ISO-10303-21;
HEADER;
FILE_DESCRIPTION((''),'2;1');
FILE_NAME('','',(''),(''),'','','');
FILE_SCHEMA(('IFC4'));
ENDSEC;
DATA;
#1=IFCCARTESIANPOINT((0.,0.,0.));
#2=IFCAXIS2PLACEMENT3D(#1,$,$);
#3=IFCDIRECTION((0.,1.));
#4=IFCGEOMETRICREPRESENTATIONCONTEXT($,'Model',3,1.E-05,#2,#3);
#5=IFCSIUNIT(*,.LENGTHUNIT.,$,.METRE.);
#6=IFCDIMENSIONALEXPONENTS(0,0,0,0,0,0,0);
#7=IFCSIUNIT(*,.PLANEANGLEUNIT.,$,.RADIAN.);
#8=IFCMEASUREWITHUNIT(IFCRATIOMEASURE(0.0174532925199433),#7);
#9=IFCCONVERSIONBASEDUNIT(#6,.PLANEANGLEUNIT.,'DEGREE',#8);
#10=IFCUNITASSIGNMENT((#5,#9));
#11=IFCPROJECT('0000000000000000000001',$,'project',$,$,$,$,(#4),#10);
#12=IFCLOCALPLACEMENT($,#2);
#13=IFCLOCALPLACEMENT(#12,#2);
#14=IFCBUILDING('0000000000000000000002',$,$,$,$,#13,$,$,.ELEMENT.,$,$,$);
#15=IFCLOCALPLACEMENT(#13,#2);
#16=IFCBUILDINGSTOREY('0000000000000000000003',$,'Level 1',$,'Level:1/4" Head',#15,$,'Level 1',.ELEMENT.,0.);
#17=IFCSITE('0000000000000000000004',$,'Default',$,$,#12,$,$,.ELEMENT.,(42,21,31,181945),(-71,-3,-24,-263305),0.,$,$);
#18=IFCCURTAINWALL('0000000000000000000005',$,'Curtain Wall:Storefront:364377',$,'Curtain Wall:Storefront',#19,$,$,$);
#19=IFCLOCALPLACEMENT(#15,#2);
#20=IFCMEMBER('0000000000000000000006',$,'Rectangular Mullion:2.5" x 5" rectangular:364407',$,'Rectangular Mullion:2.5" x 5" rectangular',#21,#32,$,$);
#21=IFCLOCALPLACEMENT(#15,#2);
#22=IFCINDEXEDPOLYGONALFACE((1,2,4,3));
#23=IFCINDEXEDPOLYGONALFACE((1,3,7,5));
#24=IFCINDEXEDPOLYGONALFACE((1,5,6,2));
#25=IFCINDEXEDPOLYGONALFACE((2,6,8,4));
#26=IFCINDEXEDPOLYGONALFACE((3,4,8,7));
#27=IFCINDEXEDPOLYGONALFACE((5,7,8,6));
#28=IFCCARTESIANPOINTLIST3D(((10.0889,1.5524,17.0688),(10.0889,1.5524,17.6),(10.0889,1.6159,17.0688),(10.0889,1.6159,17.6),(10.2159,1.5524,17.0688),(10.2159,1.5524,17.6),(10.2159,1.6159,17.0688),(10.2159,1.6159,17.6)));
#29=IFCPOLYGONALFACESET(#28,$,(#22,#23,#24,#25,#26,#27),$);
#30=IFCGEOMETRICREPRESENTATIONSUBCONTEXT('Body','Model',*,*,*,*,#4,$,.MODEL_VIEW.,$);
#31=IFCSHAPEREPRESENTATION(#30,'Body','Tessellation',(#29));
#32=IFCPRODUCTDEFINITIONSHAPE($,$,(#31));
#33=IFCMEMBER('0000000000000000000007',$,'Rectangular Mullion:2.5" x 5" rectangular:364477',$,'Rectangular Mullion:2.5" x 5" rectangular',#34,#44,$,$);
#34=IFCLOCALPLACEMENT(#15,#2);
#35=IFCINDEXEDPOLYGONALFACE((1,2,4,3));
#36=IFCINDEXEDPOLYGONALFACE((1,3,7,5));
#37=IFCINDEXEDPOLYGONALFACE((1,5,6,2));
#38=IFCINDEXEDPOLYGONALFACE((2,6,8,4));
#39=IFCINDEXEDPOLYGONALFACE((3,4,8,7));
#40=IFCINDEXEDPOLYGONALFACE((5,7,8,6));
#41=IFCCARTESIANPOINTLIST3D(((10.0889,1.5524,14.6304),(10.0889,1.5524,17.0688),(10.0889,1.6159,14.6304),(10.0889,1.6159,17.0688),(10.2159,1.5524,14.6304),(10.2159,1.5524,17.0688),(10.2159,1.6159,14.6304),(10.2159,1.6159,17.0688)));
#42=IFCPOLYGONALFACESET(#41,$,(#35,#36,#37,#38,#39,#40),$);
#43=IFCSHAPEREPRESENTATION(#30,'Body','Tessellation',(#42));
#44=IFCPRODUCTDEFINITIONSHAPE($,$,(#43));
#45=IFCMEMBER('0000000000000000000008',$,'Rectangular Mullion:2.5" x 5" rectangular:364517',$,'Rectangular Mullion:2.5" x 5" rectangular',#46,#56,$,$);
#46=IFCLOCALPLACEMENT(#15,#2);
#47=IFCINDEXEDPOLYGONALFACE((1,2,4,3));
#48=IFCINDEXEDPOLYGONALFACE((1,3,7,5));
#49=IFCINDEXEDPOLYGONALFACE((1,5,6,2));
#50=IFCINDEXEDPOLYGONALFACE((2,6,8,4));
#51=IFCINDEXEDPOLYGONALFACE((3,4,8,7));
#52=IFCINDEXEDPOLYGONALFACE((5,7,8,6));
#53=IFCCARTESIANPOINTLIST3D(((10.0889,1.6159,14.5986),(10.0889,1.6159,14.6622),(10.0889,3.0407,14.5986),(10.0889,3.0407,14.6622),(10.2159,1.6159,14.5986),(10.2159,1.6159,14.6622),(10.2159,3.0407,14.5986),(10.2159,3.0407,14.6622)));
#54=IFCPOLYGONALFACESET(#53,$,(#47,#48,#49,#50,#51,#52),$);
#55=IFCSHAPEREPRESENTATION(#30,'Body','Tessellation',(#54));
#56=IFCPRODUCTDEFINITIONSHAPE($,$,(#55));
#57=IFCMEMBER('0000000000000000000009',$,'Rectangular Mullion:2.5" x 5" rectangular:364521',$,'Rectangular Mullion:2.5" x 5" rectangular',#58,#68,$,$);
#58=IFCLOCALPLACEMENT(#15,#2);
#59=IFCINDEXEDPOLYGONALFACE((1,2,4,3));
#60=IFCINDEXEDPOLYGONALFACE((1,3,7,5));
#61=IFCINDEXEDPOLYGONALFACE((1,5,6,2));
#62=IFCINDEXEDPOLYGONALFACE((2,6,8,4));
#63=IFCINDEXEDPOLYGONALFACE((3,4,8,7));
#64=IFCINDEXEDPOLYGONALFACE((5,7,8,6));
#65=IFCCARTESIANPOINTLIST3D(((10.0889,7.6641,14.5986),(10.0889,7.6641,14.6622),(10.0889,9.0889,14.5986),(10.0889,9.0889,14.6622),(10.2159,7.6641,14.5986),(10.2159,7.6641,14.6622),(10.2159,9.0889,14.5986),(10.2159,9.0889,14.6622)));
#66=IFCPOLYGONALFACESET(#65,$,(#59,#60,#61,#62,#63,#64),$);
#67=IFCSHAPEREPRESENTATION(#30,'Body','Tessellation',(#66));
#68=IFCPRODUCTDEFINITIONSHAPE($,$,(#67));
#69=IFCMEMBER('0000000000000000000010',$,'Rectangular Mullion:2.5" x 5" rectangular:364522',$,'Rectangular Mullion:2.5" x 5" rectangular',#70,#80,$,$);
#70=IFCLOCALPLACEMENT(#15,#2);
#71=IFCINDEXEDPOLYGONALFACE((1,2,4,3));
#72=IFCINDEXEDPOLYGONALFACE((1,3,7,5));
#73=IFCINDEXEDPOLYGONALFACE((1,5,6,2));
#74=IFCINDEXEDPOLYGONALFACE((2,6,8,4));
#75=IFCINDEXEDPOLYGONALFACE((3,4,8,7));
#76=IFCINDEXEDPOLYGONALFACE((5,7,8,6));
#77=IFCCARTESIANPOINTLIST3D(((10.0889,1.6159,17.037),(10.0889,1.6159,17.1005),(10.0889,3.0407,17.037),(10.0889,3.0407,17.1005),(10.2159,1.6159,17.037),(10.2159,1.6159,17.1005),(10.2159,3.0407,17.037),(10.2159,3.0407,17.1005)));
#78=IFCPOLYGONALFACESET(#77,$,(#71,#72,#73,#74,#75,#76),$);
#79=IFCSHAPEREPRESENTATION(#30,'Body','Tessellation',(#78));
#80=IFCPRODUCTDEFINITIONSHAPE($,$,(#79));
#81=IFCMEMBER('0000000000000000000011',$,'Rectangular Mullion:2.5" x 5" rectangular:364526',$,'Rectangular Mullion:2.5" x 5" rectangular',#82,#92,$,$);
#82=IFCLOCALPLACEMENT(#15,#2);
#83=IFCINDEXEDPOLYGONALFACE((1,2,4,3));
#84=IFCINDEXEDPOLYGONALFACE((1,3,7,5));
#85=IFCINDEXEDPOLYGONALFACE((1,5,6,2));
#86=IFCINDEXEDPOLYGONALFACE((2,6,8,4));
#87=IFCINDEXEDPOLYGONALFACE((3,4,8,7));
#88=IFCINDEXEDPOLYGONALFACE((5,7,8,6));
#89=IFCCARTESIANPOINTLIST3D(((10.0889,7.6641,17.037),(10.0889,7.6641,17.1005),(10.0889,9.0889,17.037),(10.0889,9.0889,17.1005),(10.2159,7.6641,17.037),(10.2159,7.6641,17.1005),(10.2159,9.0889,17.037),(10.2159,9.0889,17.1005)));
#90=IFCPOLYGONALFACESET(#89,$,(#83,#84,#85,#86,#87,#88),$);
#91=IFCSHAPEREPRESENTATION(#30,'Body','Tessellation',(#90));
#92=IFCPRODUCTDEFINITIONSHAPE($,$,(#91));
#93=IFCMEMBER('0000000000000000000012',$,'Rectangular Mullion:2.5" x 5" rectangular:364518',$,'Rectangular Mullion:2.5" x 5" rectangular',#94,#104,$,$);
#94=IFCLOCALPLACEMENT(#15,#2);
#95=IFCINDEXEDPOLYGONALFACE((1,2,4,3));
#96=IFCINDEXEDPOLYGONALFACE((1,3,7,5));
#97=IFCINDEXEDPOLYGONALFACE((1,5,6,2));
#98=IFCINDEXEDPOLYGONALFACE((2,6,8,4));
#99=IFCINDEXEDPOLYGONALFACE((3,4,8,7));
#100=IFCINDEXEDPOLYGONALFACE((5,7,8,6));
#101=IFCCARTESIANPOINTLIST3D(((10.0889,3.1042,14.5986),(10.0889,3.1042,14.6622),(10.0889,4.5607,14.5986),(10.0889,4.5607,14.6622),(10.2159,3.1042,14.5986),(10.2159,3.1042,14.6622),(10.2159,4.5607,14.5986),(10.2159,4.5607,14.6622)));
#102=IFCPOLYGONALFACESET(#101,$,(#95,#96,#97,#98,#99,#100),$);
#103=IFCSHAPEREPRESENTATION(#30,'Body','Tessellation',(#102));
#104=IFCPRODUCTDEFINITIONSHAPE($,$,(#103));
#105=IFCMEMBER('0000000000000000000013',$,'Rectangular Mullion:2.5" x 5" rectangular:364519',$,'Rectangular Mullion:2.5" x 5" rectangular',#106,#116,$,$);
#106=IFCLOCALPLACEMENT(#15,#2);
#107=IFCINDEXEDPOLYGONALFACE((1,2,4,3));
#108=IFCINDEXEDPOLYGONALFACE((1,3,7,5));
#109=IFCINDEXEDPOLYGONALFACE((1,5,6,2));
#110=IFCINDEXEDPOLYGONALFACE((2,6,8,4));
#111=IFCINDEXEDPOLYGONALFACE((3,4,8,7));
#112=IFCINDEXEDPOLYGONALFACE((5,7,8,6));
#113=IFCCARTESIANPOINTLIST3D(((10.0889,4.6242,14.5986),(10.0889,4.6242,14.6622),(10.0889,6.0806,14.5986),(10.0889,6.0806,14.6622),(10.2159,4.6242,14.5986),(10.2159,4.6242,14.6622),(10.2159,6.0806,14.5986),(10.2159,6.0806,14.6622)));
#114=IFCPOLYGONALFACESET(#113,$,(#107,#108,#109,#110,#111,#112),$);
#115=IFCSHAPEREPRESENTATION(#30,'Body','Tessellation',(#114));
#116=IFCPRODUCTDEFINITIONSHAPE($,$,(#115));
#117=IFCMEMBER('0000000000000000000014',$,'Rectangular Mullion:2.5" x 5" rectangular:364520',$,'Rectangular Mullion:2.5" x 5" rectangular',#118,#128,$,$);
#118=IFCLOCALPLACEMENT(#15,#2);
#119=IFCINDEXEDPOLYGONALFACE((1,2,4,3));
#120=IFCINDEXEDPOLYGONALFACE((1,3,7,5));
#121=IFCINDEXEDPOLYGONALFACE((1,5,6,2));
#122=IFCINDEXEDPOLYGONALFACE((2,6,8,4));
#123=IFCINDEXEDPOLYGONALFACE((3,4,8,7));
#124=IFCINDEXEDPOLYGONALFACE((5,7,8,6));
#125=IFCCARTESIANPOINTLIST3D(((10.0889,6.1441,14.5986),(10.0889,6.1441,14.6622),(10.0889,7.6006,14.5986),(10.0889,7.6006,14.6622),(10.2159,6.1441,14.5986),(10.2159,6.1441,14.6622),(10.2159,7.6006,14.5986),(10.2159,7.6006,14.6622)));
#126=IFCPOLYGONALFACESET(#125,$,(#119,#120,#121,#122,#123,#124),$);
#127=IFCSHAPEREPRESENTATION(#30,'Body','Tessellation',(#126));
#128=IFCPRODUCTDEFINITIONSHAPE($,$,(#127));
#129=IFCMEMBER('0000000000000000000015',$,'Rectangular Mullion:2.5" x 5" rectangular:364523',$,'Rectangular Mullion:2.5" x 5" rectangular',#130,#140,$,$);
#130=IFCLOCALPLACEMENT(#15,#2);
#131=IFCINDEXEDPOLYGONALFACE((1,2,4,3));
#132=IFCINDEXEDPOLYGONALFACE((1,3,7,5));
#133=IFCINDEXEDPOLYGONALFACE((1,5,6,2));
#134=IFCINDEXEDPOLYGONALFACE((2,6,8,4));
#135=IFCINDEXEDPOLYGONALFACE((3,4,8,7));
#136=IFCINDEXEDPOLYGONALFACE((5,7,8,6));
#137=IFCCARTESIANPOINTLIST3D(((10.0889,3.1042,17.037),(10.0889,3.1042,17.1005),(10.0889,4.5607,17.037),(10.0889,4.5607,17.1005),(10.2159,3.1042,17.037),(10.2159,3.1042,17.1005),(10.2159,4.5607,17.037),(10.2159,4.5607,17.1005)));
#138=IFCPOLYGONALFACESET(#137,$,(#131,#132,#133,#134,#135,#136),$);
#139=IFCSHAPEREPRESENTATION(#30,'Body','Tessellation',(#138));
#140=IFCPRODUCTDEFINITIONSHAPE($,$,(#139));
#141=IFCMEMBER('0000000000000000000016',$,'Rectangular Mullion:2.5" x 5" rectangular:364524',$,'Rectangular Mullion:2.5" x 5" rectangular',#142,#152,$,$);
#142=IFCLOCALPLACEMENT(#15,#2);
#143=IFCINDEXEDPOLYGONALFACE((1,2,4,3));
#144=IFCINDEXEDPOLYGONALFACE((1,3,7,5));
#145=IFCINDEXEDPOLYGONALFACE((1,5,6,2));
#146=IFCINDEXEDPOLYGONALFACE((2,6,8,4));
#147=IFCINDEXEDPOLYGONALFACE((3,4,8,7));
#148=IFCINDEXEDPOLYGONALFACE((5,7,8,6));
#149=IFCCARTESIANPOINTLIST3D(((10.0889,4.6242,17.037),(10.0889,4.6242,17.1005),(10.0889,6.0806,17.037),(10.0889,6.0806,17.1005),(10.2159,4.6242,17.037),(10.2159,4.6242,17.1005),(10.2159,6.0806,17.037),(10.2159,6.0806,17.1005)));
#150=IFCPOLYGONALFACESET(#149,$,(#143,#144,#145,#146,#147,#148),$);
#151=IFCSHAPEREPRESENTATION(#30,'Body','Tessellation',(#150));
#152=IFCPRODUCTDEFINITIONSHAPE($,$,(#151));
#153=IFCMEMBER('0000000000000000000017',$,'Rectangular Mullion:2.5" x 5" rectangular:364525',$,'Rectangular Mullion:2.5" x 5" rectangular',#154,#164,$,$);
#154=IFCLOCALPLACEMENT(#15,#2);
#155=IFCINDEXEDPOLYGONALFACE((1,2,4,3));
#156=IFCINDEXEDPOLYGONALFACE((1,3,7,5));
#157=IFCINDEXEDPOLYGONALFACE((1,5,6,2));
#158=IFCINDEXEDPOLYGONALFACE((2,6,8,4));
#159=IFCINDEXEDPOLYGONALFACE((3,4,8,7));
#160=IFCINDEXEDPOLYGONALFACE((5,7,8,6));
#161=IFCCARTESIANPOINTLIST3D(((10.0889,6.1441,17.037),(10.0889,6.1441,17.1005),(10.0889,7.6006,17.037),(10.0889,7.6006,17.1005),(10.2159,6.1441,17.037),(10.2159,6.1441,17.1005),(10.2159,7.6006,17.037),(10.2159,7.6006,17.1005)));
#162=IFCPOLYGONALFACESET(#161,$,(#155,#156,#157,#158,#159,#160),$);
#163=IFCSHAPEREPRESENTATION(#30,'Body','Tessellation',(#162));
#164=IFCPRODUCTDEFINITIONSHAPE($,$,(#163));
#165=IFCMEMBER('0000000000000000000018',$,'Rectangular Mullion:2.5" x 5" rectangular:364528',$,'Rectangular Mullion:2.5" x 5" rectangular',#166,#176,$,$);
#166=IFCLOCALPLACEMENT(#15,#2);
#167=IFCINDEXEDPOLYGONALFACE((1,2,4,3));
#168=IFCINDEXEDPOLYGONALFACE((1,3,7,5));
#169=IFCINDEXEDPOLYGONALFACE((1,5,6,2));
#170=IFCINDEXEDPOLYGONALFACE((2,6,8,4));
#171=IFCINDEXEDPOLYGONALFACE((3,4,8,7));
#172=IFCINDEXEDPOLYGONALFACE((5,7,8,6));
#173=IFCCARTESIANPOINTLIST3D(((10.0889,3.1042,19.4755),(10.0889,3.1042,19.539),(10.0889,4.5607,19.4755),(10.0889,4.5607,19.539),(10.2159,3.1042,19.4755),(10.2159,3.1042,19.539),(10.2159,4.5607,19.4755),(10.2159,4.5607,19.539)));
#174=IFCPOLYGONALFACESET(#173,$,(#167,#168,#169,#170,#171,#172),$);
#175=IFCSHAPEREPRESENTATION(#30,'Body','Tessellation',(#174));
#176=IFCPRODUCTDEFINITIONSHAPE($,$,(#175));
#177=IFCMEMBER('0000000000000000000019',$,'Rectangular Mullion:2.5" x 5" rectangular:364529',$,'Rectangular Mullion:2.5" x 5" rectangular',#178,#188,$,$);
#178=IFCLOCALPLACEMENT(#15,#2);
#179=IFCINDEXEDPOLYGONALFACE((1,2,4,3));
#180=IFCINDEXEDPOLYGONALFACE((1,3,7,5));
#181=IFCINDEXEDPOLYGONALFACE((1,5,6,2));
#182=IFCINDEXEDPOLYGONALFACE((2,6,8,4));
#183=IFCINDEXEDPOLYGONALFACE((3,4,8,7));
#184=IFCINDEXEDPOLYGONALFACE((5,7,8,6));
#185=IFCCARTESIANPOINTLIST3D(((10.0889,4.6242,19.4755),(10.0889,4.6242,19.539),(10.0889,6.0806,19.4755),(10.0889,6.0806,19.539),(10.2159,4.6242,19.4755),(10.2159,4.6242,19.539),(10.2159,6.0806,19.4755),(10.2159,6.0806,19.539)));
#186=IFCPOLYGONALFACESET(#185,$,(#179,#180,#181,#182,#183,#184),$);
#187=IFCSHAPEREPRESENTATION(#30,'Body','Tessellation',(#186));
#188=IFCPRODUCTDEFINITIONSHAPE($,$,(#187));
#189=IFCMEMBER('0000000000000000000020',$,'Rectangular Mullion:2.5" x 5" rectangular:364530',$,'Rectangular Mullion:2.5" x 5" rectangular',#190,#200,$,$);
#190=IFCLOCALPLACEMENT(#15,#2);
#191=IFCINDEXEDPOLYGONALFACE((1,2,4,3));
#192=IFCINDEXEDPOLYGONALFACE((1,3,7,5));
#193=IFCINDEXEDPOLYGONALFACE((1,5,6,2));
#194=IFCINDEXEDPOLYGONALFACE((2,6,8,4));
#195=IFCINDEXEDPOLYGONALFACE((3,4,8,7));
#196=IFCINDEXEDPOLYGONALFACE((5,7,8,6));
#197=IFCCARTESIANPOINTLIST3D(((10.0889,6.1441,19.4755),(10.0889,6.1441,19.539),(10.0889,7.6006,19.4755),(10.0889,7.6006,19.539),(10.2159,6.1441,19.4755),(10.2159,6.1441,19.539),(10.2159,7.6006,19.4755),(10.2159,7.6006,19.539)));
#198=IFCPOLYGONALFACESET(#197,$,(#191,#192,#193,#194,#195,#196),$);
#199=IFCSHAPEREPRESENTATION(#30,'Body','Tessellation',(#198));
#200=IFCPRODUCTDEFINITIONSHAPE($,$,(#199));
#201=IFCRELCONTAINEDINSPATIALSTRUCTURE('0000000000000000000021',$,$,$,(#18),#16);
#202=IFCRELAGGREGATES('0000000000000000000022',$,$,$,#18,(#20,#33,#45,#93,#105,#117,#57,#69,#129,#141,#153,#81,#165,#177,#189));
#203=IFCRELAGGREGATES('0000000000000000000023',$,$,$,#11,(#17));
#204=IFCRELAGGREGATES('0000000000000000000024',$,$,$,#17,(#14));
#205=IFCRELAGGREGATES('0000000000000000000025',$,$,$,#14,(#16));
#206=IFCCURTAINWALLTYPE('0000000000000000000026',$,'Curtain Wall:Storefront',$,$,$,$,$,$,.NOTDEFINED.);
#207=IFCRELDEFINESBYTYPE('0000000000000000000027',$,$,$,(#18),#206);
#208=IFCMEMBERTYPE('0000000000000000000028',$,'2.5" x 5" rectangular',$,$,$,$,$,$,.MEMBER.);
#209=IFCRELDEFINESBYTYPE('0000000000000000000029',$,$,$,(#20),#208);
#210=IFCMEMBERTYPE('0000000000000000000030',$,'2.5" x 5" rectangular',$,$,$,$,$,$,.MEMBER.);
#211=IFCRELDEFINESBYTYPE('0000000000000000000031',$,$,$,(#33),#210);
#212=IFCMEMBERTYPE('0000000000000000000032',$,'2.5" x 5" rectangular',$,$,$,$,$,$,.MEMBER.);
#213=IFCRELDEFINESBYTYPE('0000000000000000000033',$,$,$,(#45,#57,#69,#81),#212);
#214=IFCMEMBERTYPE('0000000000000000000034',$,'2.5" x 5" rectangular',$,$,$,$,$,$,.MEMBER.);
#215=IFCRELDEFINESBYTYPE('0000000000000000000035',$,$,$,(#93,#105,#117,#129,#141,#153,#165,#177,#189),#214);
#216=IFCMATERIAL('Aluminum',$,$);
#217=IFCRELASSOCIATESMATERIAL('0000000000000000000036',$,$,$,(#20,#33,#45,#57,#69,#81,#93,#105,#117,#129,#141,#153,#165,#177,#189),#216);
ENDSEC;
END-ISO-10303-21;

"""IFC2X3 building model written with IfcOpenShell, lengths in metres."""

from ifc_helpers import new_model, entity, si_unit, converted_unit, direction, frame, origin, origin_2d_with_axis, place, context, subcontext, project, spatial, rectangle, extrude, source, transform, mapped, material, type_object, type_shapes, element, aggregate, save


model = new_model("IFC2X3")

# Units and contexts
model_context = context("Model", 3, precision=1e-05, world=origin(), true_north=direction((0.0, 1.0)))
body_context = subcontext(model_context, "Body", "Model", "MODEL_VIEW")
ifc_project = project(units=[si_unit("LENGTHUNIT", "METRE"), converted_unit("PLANEANGLEUNIT", "DEGREE", entity("IfcRatioMeasure", 0.0174532925199433), si_unit("PLANEANGLEUNIT", "RADIAN"), dimensions=[0, 0, 0, 0, 0, 0, 0])], contexts=[model_context])

# Site, building, storey
site_placement = place(None, origin())
site = spatial("IfcSite", under=ifc_project, at=site_placement, Name="Default", CompositionType="ELEMENT", RefLatitude=(42, 21, 31, 181945), RefLongitude=(-71, -3, -24, -263305), RefElevation=0.0)
building_placement = place(site_placement, origin())
building = spatial("IfcBuilding", under=site, at=building_placement, CompositionType="ELEMENT")
storey_placement = place(building_placement, origin())
storey = spatial("IfcBuildingStorey", under=building, at=storey_placement, Name="Level 1", ObjectType="Level:1/4\" Head", LongName="Level 1", CompositionType="ELEMENT", Elevation=0.0)

# Curtain wall, members
curtain_wall_type = type_object("IfcCurtainWallType", Name="Curtain Wall:Storefront", PredefinedType="NOTDEFINED")
curtain_wall_placement = place(storey_placement, origin())
curtain_wall = element("IfcCurtainWall", 1, at=curtain_wall_placement, inside=storey, type_object=curtain_wall_type, Name="Curtain Wall:Storefront:364377", ObjectType="Curtain Wall:Storefront")
ifc_material_1 = material(Name="Aluminum")
member_type_1 = type_object("IfcMemberType", Name="2.5\" x 5\" rectangular", PredefinedType="MEMBER")
shared_shape_1 = source(origin(), body_context, "Body", "SweptSolid", [
    extrude(rectangle(XDim=0.127, YDim=0.0635, at=origin_2d_with_axis()), frame((-0.0318, 0.0, -0.5312), z_axis=(0.0, 0.0, 1.0), x_axis=(0.0, -1.0, 0.0)), (0.0, 0.0, 1.0), 0.5312),
])
type_shapes(member_type_1, [shared_shape_1])
member_1_placement = place(storey_placement, frame((10.1524, 1.5524, 17.6), z_axis=(0.0, 0.0, 1.0), x_axis=(0.0, -1.0, 0.0)))
member_1 = element("IfcMember", 2, at=member_1_placement, type_object=member_type_1, material=ifc_material_1, Name="Rectangular Mullion:2.5\" x 5\" rectangular:364407", ObjectType="Rectangular Mullion:2.5\" x 5\" rectangular", context=body_context, shape_type="MappedRepresentation", body=[
    mapped(shared_shape_1, transform((0.0, 0.0, 0.0), scale=1.0)),
])
member_type_2 = type_object("IfcMemberType", Name="2.5\" x 5\" rectangular", PredefinedType="MEMBER")
shared_shape_2 = source(origin(), body_context, "Body", "SweptSolid", [
    extrude(rectangle(XDim=0.127, YDim=0.0635, at=origin_2d_with_axis()), frame((-0.0318, 0.0, -2.4384), z_axis=(0.0, 0.0, 1.0), x_axis=(0.0, -1.0, 0.0)), (0.0, 0.0, 1.0), 2.4384),
])
type_shapes(member_type_2, [shared_shape_2])
member_2_placement = place(storey_placement, frame((10.1524, 1.5524, 17.0688), z_axis=(0.0, 0.0, 1.0), x_axis=(0.0, -1.0, 0.0)))
member_2 = element("IfcMember", 3, at=member_2_placement, type_object=member_type_2, material=ifc_material_1, Name="Rectangular Mullion:2.5\" x 5\" rectangular:364477", ObjectType="Rectangular Mullion:2.5\" x 5\" rectangular", context=body_context, shape_type="MappedRepresentation", body=[
    mapped(shared_shape_2, transform((0.0, 0.0, 0.0), scale=1.0)),
])
member_type_3 = type_object("IfcMemberType", Name="2.5\" x 5\" rectangular", PredefinedType="MEMBER")
shared_shape_3 = source(origin(), body_context, "Body", "SweptSolid", [
    extrude(rectangle(XDim=0.127, YDim=0.0635, at=origin_2d_with_axis()), frame((0.0, 0.0, -1.4248), z_axis=(0.0, 0.0, 1.0), x_axis=(0.0, -1.0, 0.0)), (0.0, 0.0, 1.0), 1.4248),
])
type_shapes(member_type_3, [shared_shape_3])
member_3_placement = place(storey_placement, frame((10.1524, 3.0407, 14.6304), z_axis=(0.0, 1.0, 0.0), x_axis=(0.0, 0.0, 1.0)))
member_3 = element("IfcMember", 4, at=member_3_placement, type_object=member_type_3, material=ifc_material_1, Name="Rectangular Mullion:2.5\" x 5\" rectangular:364517", ObjectType="Rectangular Mullion:2.5\" x 5\" rectangular", context=body_context, shape_type="MappedRepresentation", body=[
    mapped(shared_shape_3, transform((0.0, 0.0, 0.0), scale=1.0)),
])
member_4_placement = place(storey_placement, frame((10.1524, 9.0889, 14.6304), z_axis=(0.0, 1.0, 0.0), x_axis=(0.0, 0.0, 1.0)))
member_4 = element("IfcMember", 5, at=member_4_placement, type_object=member_type_3, material=ifc_material_1, Name="Rectangular Mullion:2.5\" x 5\" rectangular:364521", ObjectType="Rectangular Mullion:2.5\" x 5\" rectangular", context=body_context, shape_type="MappedRepresentation", body=[
    mapped(shared_shape_3, transform((0.0, 0.0, 0.0), scale=1.0)),
])
member_5_placement = place(storey_placement, frame((10.1524, 3.0407, 17.0688), z_axis=(0.0, 1.0, 0.0), x_axis=(0.0, 0.0, 1.0)))
member_5 = element("IfcMember", 6, at=member_5_placement, type_object=member_type_3, material=ifc_material_1, Name="Rectangular Mullion:2.5\" x 5\" rectangular:364522", ObjectType="Rectangular Mullion:2.5\" x 5\" rectangular", context=body_context, shape_type="MappedRepresentation", body=[
    mapped(shared_shape_3, transform((0.0, 0.0, 0.0), scale=1.0)),
])
member_6_placement = place(storey_placement, frame((10.1524, 9.0889, 17.0688), z_axis=(0.0, 1.0, 0.0), x_axis=(0.0, 0.0, 1.0)))
member_6 = element("IfcMember", 7, at=member_6_placement, type_object=member_type_3, material=ifc_material_1, Name="Rectangular Mullion:2.5\" x 5\" rectangular:364526", ObjectType="Rectangular Mullion:2.5\" x 5\" rectangular", context=body_context, shape_type="MappedRepresentation", body=[
    mapped(shared_shape_3, transform((0.0, 0.0, 0.0), scale=1.0)),
])
member_type_4 = type_object("IfcMemberType", Name="2.5\" x 5\" rectangular", PredefinedType="MEMBER")
shared_shape_4 = source(origin(), body_context, "Body", "SweptSolid", [
    extrude(rectangle(XDim=0.127, YDim=0.0635, at=origin_2d_with_axis()), frame((0.0, 0.0, -1.4565), z_axis=(0.0, 0.0, 1.0), x_axis=(0.0, -1.0, 0.0)), (0.0, 0.0, 1.0), 1.4565),
])
type_shapes(member_type_4, [shared_shape_4])
member_7_placement = place(storey_placement, frame((10.1524, 4.5607, 14.6304), z_axis=(0.0, 1.0, 0.0), x_axis=(0.0, 0.0, 1.0)))
member_7 = element("IfcMember", 8, at=member_7_placement, type_object=member_type_4, material=ifc_material_1, Name="Rectangular Mullion:2.5\" x 5\" rectangular:364518", ObjectType="Rectangular Mullion:2.5\" x 5\" rectangular", context=body_context, shape_type="MappedRepresentation", body=[
    mapped(shared_shape_4, transform((0.0, 0.0, 0.0), scale=1.0)),
])
member_8_placement = place(storey_placement, frame((10.1524, 6.0806, 14.6304), z_axis=(0.0, 1.0, 0.0), x_axis=(0.0, 0.0, 1.0)))
member_8 = element("IfcMember", 9, at=member_8_placement, type_object=member_type_4, material=ifc_material_1, Name="Rectangular Mullion:2.5\" x 5\" rectangular:364519", ObjectType="Rectangular Mullion:2.5\" x 5\" rectangular", context=body_context, shape_type="MappedRepresentation", body=[
    mapped(shared_shape_4, transform((0.0, 0.0, 0.0), scale=1.0)),
])
member_9_placement = place(storey_placement, frame((10.1524, 7.6006, 14.6304), z_axis=(0.0, 1.0, 0.0), x_axis=(0.0, 0.0, 1.0)))
member_9 = element("IfcMember", 10, at=member_9_placement, type_object=member_type_4, material=ifc_material_1, Name="Rectangular Mullion:2.5\" x 5\" rectangular:364520", ObjectType="Rectangular Mullion:2.5\" x 5\" rectangular", context=body_context, shape_type="MappedRepresentation", body=[
    mapped(shared_shape_4, transform((0.0, 0.0, 0.0), scale=1.0)),
])
member_10_placement = place(storey_placement, frame((10.1524, 4.5607, 17.0688), z_axis=(0.0, 1.0, 0.0), x_axis=(0.0, 0.0, 1.0)))
member_10 = element("IfcMember", 11, at=member_10_placement, type_object=member_type_4, material=ifc_material_1, Name="Rectangular Mullion:2.5\" x 5\" rectangular:364523", ObjectType="Rectangular Mullion:2.5\" x 5\" rectangular", context=body_context, shape_type="MappedRepresentation", body=[
    mapped(shared_shape_4, transform((0.0, 0.0, 0.0), scale=1.0)),
])
member_11_placement = place(storey_placement, frame((10.1524, 6.0806, 17.0688), z_axis=(0.0, 1.0, 0.0), x_axis=(0.0, 0.0, 1.0)))
member_11 = element("IfcMember", 12, at=member_11_placement, type_object=member_type_4, material=ifc_material_1, Name="Rectangular Mullion:2.5\" x 5\" rectangular:364524", ObjectType="Rectangular Mullion:2.5\" x 5\" rectangular", context=body_context, shape_type="MappedRepresentation", body=[
    mapped(shared_shape_4, transform((0.0, 0.0, 0.0), scale=1.0)),
])
member_12_placement = place(storey_placement, frame((10.1524, 7.6006, 17.0688), z_axis=(0.0, 1.0, 0.0), x_axis=(0.0, 0.0, 1.0)))
member_12 = element("IfcMember", 13, at=member_12_placement, type_object=member_type_4, material=ifc_material_1, Name="Rectangular Mullion:2.5\" x 5\" rectangular:364525", ObjectType="Rectangular Mullion:2.5\" x 5\" rectangular", context=body_context, shape_type="MappedRepresentation", body=[
    mapped(shared_shape_4, transform((0.0, 0.0, 0.0), scale=1.0)),
])
member_13_placement = place(storey_placement, frame((10.1524, 4.5607, 19.5072), z_axis=(0.0, 1.0, 0.0), x_axis=(0.0, 0.0, 1.0)))
member_13 = element("IfcMember", 14, at=member_13_placement, type_object=member_type_4, material=ifc_material_1, Name="Rectangular Mullion:2.5\" x 5\" rectangular:364528", ObjectType="Rectangular Mullion:2.5\" x 5\" rectangular", context=body_context, shape_type="MappedRepresentation", body=[
    mapped(shared_shape_4, transform((0.0, 0.0, 0.0), scale=1.0)),
])
member_14_placement = place(storey_placement, frame((10.1524, 6.0806, 19.5072), z_axis=(0.0, 1.0, 0.0), x_axis=(0.0, 0.0, 1.0)))
member_14 = element("IfcMember", 15, at=member_14_placement, type_object=member_type_4, material=ifc_material_1, Name="Rectangular Mullion:2.5\" x 5\" rectangular:364529", ObjectType="Rectangular Mullion:2.5\" x 5\" rectangular", context=body_context, shape_type="MappedRepresentation", body=[
    mapped(shared_shape_4, transform((0.0, 0.0, 0.0), scale=1.0)),
])
member_15_placement = place(storey_placement, frame((10.1524, 7.6006, 19.5072), z_axis=(0.0, 1.0, 0.0), x_axis=(0.0, 0.0, 1.0)))
member_15 = element("IfcMember", 16, at=member_15_placement, type_object=member_type_4, material=ifc_material_1, Name="Rectangular Mullion:2.5\" x 5\" rectangular:364530", ObjectType="Rectangular Mullion:2.5\" x 5\" rectangular", context=body_context, shape_type="MappedRepresentation", body=[
    mapped(shared_shape_4, transform((0.0, 0.0, 0.0), scale=1.0)),
])
aggregate(curtain_wall, [member_1, member_2, member_3, member_7, member_8, member_9, member_4, member_5, member_10, member_11, member_12, member_6, member_13, member_14, member_15])

save(model, "model.ifc")
